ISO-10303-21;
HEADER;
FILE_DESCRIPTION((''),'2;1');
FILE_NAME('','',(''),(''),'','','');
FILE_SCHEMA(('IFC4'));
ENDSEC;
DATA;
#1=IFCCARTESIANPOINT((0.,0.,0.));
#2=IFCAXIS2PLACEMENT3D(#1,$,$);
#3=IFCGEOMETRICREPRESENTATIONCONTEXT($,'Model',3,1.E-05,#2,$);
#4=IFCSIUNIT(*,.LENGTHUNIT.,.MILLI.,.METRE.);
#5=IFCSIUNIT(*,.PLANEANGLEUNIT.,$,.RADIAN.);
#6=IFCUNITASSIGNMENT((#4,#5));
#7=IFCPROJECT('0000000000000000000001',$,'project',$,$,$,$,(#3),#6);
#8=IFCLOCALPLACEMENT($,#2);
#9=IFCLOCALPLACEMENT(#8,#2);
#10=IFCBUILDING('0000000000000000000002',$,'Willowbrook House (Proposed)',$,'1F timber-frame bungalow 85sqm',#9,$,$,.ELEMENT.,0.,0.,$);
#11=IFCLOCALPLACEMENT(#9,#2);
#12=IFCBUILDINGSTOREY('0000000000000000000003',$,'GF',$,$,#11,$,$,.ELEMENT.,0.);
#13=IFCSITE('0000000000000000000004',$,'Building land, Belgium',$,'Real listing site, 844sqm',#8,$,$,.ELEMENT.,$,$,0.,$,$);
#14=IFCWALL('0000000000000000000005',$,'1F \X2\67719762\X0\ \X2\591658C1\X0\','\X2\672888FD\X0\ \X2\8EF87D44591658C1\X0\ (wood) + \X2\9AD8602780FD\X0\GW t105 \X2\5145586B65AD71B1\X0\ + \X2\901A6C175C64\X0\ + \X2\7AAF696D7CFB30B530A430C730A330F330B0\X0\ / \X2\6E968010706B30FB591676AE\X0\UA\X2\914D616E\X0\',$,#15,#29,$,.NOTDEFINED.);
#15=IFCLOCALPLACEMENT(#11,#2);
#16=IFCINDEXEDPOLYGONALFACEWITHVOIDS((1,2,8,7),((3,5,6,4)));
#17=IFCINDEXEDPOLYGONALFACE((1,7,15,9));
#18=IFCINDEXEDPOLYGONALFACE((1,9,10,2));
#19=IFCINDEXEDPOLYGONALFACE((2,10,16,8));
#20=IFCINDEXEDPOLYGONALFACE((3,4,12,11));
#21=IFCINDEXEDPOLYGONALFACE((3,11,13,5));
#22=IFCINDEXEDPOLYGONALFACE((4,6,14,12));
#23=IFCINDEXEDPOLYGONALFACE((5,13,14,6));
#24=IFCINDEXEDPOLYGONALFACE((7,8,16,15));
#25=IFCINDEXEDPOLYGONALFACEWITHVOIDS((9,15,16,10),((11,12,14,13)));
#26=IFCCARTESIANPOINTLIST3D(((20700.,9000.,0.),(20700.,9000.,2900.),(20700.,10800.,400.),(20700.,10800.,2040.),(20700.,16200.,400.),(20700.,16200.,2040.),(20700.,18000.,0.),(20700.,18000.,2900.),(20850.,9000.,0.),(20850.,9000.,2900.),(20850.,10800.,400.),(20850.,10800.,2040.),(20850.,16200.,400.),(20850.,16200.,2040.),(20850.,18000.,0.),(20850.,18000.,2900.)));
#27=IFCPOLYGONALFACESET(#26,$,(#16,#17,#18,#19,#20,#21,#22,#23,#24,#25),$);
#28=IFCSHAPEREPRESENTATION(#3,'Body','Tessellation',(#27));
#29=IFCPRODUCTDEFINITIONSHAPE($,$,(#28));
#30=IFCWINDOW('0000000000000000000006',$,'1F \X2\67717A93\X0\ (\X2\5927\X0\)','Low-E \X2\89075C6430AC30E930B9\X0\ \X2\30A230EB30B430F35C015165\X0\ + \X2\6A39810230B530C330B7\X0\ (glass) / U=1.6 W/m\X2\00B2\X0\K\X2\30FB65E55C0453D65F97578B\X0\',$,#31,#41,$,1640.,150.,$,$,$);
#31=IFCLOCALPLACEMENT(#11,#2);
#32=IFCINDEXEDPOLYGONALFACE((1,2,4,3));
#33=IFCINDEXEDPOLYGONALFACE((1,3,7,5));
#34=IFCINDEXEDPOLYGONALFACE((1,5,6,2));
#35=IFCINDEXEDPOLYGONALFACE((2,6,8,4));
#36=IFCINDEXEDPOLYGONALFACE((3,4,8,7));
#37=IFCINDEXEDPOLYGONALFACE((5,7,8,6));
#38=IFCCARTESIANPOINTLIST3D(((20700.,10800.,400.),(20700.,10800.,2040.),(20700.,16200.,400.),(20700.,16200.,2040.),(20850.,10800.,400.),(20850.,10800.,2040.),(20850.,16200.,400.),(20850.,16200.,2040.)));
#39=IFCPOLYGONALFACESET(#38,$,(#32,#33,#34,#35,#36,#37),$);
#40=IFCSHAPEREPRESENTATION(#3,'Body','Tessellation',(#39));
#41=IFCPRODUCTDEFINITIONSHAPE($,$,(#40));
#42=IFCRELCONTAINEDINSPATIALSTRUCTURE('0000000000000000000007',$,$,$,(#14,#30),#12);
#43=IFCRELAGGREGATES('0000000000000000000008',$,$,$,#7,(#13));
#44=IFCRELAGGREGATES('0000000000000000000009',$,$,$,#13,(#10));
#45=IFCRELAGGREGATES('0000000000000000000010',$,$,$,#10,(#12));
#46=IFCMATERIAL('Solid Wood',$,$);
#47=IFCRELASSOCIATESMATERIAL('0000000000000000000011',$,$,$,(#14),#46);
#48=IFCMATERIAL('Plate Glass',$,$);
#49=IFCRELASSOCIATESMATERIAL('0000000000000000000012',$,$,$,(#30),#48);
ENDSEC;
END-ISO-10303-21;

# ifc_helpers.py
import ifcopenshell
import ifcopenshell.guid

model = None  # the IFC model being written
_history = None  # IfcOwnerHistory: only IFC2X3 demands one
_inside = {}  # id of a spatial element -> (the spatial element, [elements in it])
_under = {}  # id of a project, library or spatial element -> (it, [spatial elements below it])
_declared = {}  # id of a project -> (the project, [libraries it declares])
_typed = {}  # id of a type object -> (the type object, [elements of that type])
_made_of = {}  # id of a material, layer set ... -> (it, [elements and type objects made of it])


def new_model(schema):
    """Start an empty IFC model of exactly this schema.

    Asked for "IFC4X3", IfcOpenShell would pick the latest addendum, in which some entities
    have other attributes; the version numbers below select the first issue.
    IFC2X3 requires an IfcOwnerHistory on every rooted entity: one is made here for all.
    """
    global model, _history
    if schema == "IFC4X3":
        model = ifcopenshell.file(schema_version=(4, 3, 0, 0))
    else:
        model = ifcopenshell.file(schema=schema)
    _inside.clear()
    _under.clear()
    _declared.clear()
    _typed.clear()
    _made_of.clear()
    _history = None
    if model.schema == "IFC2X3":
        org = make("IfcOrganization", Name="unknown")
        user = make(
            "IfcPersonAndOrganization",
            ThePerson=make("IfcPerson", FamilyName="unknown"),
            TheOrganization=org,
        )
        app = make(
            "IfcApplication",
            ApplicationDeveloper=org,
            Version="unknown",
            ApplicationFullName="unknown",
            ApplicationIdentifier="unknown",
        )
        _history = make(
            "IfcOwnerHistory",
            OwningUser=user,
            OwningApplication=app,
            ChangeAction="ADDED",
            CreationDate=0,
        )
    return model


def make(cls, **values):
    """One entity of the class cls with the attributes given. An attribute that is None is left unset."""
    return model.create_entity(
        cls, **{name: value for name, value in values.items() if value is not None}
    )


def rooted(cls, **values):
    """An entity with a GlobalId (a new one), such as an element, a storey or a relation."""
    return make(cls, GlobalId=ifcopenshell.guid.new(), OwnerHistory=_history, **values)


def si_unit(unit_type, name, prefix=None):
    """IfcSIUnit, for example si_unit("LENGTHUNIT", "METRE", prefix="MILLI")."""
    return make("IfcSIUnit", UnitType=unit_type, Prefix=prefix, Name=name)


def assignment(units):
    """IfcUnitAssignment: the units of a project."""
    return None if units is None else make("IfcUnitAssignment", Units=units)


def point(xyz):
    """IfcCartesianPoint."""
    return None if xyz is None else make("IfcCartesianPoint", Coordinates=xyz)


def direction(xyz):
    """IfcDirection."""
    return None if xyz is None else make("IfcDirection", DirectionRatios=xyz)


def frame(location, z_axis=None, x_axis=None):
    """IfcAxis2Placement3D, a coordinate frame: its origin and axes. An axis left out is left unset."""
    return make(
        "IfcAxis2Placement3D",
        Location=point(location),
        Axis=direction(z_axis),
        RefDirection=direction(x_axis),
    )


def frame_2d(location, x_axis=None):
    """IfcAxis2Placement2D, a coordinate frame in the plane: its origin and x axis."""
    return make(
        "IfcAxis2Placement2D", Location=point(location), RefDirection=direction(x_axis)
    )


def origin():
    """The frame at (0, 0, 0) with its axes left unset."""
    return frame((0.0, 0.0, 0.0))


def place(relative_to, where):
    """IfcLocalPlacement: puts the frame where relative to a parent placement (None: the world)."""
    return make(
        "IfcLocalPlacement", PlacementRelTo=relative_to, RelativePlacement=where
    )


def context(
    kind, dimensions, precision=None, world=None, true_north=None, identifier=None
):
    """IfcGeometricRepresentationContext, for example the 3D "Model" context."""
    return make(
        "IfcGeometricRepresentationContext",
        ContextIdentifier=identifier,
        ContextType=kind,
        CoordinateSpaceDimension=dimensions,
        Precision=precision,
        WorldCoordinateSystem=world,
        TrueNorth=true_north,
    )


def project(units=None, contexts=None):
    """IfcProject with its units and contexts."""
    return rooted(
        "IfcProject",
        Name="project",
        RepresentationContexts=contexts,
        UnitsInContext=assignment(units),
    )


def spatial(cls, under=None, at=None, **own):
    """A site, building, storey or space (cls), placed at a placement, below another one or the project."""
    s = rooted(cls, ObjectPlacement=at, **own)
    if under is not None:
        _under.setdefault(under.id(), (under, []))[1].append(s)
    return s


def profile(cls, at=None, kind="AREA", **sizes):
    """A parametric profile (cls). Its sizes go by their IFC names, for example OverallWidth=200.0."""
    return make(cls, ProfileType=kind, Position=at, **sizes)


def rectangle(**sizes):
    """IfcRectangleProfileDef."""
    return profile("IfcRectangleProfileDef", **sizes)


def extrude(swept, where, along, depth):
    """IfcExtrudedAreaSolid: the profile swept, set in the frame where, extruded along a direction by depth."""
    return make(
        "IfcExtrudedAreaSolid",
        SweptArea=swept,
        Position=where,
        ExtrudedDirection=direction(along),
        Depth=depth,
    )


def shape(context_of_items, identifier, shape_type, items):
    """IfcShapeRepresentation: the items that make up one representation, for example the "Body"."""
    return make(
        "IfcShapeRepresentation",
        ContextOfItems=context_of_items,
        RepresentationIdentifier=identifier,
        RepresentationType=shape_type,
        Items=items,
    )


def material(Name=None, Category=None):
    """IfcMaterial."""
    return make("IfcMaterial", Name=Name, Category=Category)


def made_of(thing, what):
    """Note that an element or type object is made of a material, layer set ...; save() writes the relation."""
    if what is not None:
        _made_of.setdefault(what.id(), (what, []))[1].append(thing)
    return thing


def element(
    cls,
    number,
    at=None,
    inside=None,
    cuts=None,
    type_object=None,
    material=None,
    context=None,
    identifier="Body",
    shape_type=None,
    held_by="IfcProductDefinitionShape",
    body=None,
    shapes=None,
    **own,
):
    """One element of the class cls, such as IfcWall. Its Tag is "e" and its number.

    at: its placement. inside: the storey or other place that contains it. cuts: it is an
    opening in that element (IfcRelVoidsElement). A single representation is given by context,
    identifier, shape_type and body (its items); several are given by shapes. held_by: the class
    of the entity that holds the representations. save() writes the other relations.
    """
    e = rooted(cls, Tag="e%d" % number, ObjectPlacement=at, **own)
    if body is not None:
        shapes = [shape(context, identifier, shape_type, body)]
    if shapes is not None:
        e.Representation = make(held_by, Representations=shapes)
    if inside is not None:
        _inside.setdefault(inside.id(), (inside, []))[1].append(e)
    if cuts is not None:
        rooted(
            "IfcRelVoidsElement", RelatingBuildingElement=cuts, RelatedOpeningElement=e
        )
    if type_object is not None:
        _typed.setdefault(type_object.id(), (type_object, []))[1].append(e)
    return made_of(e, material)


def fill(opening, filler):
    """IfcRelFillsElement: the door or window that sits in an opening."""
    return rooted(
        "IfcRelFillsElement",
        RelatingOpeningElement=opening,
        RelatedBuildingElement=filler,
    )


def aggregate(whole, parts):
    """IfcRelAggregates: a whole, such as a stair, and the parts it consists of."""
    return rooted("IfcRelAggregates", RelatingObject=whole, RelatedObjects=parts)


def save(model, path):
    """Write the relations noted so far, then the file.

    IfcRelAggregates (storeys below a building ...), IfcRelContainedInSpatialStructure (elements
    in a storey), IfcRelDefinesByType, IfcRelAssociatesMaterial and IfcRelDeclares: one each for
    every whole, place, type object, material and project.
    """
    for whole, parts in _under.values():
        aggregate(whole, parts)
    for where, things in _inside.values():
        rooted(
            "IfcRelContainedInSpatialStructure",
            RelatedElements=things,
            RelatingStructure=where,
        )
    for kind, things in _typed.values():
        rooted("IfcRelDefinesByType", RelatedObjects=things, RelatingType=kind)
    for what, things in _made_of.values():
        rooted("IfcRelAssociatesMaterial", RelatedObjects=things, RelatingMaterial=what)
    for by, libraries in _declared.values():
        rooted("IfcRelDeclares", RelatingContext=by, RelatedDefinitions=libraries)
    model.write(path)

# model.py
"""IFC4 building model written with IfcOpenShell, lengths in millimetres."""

from ifc_helpers import new_model, si_unit, frame, frame_2d, origin, place, context, project, spatial, rectangle, extrude, material, element, fill, save


model = new_model("IFC4")

# Units and contexts
model_context = context("Model", 3, precision=1e-05, world=origin())
ifc_project = project(units=[si_unit("LENGTHUNIT", "METRE", prefix="MILLI"), si_unit("PLANEANGLEUNIT", "RADIAN")], contexts=[model_context])

# Site, building, storey
site_placement = place(None, origin())
site = spatial("IfcSite", under=ifc_project, at=site_placement, Name="Building land, Belgium", ObjectType="Real listing site, 844sqm", CompositionType="ELEMENT", RefElevation=0.0)
building_placement = place(site_placement, origin())
building = spatial("IfcBuilding", under=site, at=building_placement, Name="Willowbrook House (Proposed)", ObjectType="1F timber-frame bungalow 85sqm", CompositionType="ELEMENT", ElevationOfRefHeight=0.0, ElevationOfTerrain=0.0)
storey_placement = place(building_placement, origin())
storey = spatial("IfcBuildingStorey", under=building, at=storey_placement, Name="GF", CompositionType="ELEMENT", Elevation=0.0)

# Wall, opening, window
ifc_material_1 = material(Name="Solid Wood")
wall_1_placement = place(storey_placement, frame((10350.0, 4500.0, 0.0)))
wall_1 = element("IfcWall", 1, at=wall_1_placement, inside=storey, material=ifc_material_1, Name="1F 東面 外壁", Description="木製 軸組外壁 (wood) + 高性能GW t105 充填断熱 + 通気層 + 窯業系サイディング / 準耐火・外皮UA配慮", PredefinedType="NOTDEFINED", context=model_context, shape_type="SweptSolid", body=[
    extrude(rectangle(XDim=150.0, YDim=9000.0, at=frame_2d((75.0, 4500.0))), frame((10350.0, 4500.0, 0.0)), (0.0, 0.0, 1.0), 2900.0),
])
opening_1_placement = place(storey_placement, frame((10350.0, 5400.0, 200.0)))
opening_1 = element("IfcOpeningElement", 2, at=opening_1_placement, cuts=wall_1, PredefinedType="NOTDEFINED", context=model_context, shape_type="SweptSolid", body=[
    extrude(rectangle(XDim=150.0, YDim=5400.0, at=frame_2d((75.0, 2700.0))), frame((10350.0, 5400.0, 200.0)), (0.0, 0.0, 1.0), 1640.0),
])
ifc_material_2 = material(Name="Plate Glass")
window_1_placement = place(storey_placement, frame((10350.0, 5400.0, 200.0)))
window_1 = element("IfcWindow", 3, at=window_1_placement, inside=storey, material=ifc_material_2, Name="1F 東窓 (大)", Description="Low-E 複層ガラス アルゴン封入 + 樹脂サッシ (glass) / U=1.6 W/m²K・日射取得型", OverallHeight=1640.0, OverallWidth=150.0, context=model_context, shape_type="SweptSolid", body=[
    extrude(rectangle(XDim=150.0, YDim=5400.0, at=frame_2d((75.0, 2700.0))), frame((10350.0, 5400.0, 200.0)), (0.0, 0.0, 1.0), 1640.0),
])
fill(opening_1, window_1)

save(model, "model.ifc")
